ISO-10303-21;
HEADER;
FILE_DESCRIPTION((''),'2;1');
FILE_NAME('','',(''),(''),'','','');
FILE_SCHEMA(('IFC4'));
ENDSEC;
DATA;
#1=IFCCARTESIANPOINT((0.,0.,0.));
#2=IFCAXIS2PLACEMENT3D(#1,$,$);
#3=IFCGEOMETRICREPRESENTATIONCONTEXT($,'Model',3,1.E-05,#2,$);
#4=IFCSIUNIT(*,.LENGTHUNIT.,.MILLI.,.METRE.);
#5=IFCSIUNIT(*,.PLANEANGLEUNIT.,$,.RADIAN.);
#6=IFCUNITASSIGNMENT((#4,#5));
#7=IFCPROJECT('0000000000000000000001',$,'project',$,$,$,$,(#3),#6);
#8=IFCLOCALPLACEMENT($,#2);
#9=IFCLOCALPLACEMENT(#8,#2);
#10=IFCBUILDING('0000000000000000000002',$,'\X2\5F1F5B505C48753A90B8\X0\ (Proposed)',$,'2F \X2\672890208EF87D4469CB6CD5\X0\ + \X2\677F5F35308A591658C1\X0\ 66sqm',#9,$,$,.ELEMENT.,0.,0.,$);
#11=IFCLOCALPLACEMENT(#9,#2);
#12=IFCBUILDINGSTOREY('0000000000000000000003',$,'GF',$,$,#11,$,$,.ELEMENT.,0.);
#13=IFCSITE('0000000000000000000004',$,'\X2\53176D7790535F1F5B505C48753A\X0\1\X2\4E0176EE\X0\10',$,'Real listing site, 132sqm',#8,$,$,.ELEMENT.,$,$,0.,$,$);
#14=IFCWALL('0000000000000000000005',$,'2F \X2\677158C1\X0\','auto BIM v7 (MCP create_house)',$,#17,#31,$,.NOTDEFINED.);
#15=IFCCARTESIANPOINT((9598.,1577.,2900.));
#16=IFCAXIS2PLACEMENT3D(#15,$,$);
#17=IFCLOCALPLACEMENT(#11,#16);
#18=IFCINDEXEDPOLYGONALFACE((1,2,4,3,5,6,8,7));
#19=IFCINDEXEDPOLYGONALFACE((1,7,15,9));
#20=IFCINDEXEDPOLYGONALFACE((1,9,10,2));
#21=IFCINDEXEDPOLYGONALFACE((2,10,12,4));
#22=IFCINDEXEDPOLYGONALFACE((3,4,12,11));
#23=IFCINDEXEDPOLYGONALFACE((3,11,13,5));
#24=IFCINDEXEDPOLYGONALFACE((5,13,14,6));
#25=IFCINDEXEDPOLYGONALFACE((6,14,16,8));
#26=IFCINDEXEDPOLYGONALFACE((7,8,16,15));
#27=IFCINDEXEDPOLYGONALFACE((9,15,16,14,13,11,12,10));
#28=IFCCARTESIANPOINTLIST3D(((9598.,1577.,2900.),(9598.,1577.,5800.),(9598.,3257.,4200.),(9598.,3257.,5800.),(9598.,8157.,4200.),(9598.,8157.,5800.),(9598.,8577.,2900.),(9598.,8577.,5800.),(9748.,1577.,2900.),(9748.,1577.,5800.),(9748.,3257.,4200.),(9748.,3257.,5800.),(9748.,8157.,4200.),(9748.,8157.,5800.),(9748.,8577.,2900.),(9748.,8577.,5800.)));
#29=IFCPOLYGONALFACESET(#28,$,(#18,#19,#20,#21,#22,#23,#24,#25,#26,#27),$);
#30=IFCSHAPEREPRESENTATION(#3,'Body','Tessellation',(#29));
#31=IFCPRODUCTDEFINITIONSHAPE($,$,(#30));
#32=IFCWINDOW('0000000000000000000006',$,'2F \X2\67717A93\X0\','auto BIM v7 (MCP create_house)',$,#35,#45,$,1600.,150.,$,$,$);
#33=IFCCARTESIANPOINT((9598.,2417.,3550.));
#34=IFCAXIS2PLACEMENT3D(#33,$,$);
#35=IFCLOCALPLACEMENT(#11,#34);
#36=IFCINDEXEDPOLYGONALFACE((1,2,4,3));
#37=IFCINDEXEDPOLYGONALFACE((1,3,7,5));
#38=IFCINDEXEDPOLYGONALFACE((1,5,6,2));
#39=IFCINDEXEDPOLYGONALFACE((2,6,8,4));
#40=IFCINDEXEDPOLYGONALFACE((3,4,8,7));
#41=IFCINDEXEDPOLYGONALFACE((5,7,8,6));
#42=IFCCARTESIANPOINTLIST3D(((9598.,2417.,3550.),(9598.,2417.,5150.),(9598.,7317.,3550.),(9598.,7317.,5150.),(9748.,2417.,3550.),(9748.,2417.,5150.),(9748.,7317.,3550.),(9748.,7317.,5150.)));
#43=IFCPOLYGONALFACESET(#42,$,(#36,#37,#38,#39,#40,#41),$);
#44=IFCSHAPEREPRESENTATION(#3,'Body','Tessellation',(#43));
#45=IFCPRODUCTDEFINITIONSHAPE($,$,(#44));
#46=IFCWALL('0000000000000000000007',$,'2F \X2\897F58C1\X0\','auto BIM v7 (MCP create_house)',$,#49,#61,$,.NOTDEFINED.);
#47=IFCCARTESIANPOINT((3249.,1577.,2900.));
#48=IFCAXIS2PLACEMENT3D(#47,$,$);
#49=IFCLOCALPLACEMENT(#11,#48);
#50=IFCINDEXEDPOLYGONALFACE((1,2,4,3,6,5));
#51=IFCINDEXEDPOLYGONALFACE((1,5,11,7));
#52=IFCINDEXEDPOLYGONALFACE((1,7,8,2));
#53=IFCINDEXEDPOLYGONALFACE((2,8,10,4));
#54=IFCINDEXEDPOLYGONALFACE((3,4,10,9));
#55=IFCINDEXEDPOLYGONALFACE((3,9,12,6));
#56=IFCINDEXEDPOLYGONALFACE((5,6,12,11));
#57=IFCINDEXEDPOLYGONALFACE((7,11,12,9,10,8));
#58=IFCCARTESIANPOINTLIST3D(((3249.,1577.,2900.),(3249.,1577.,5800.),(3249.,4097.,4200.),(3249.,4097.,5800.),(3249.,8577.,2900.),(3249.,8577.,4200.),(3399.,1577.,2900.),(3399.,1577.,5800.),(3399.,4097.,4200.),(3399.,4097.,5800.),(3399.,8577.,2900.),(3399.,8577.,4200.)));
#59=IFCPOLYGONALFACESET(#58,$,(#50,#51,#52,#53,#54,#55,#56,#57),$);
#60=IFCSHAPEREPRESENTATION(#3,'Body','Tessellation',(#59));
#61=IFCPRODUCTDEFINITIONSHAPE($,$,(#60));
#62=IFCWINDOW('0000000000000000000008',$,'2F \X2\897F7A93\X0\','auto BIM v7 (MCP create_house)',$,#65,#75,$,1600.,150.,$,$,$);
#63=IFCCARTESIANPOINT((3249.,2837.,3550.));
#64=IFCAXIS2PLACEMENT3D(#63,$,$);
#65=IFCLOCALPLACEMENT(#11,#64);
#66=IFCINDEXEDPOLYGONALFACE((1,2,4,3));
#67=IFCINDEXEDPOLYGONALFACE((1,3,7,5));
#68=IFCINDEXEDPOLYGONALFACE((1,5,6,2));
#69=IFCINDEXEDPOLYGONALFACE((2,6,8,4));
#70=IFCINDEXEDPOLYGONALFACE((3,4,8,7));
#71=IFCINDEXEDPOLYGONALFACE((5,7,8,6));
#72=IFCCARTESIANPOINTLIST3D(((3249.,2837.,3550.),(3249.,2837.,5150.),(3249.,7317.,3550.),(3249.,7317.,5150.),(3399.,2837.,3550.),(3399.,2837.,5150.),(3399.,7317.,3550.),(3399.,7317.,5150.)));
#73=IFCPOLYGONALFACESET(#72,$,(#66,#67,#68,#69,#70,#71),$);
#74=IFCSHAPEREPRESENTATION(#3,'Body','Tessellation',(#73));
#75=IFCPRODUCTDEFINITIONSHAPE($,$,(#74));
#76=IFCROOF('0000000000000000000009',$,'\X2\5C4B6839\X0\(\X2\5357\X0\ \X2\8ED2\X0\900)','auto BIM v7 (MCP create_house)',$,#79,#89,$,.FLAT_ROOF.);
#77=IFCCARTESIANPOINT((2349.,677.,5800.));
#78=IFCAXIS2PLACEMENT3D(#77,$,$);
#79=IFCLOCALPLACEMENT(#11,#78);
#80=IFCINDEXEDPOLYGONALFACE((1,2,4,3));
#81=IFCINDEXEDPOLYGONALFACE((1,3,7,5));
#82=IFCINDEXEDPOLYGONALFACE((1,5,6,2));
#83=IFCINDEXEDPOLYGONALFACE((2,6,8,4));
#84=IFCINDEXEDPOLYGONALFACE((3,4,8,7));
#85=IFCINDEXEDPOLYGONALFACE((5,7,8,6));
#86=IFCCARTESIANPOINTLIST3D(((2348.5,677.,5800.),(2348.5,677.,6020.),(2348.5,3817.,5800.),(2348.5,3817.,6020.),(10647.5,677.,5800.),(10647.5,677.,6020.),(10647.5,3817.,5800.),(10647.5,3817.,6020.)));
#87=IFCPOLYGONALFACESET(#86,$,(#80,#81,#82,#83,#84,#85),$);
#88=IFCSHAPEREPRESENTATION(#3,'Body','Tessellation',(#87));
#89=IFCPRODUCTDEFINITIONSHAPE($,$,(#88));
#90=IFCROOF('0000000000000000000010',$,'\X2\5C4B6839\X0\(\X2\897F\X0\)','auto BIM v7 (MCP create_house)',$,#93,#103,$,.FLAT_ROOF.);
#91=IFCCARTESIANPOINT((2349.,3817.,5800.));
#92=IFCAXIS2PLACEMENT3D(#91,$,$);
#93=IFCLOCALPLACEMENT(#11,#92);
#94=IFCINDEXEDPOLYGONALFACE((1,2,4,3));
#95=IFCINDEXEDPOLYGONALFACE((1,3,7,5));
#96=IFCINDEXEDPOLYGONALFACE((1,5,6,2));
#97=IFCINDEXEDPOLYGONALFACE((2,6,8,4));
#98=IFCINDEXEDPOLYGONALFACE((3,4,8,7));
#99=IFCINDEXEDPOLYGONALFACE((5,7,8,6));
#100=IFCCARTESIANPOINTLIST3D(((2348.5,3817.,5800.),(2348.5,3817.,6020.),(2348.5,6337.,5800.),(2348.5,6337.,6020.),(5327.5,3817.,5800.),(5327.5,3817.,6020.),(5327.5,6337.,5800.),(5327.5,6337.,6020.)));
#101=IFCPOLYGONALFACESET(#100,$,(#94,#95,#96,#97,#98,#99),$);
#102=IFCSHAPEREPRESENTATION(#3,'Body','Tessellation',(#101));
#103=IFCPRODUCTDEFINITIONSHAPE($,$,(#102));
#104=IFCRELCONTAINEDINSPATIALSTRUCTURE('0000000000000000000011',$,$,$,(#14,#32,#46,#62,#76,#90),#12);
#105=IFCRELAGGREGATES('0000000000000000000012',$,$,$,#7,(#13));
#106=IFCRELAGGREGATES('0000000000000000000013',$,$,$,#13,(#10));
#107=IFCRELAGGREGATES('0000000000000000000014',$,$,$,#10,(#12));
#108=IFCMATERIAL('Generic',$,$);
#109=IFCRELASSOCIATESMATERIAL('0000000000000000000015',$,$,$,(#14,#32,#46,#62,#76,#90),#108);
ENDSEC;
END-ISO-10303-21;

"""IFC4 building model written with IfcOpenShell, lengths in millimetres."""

from ifc_helpers import new_model, si_unit, frame, frame_2d, origin, place, context, project, spatial, rectangle, extrude, material, element, fill, save


model = new_model("IFC4")

# Units and contexts
model_context = context("Model", 3, precision=1e-05, world=origin())
ifc_project = project(units=[si_unit("LENGTHUNIT", "METRE", prefix="MILLI"), si_unit("PLANEANGLEUNIT", "RADIAN")], contexts=[model_context])

# Site, building, storey
site_placement = place(None, origin())
site = spatial("IfcSite", under=ifc_project, at=site_placement, Name="北海道弟子屈町1丁目10", ObjectType="Real listing site, 132sqm", CompositionType="ELEMENT", RefElevation=0.0)
building_placement = place(site_placement, origin())
building = spatial("IfcBuilding", under=site, at=building_placement, Name="弟子屈町邸 (Proposed)", ObjectType="2F 木造軸組構法 + 板張り外壁 66sqm", CompositionType="ELEMENT", ElevationOfRefHeight=0.0, ElevationOfTerrain=0.0)
storey_placement = place(building_placement, origin())
storey = spatial("IfcBuildingStorey", under=building, at=storey_placement, Name="GF", CompositionType="ELEMENT", Elevation=0.0)

# Shared definitions
ifc_material = material(Name="Generic")

# Walls, openings, windows
wall_1_placement = place(storey_placement, frame((9598.0, 1577.0, 2900.0)))
wall_1 = element("IfcWall", 1, at=wall_1_placement, inside=storey, material=ifc_material, Name="2F 東壁", Description="auto BIM v7 (MCP create_house)", PredefinedType="NOTDEFINED", context=model_context, shape_type="SweptSolid", body=[
    extrude(rectangle(XDim=150.0, YDim=7000.0, at=frame_2d((75.0, 3500.0))), frame((9598.0, 1577.0, 2900.0)), (0.0, 0.0, 1.0), 2900.0),
])
opening_1_placement = place(storey_placement, frame((9598.0, 2417.0, 3550.0)))
opening_1 = element("IfcOpeningElement", 2, at=opening_1_placement, cuts=wall_1, PredefinedType="NOTDEFINED", context=model_context, shape_type="SweptSolid", body=[
    extrude(rectangle(XDim=150.0, YDim=4900.0, at=frame_2d((75.0, 2450.0))), frame((9598.0, 2417.0, 3550.0)), (0.0, 0.0, 1.0), 1600.0),
])
window_1_placement = place(storey_placement, frame((9598.0, 2417.0, 3550.0)))
window_1 = element("IfcWindow", 3, at=window_1_placement, inside=storey, material=ifc_material, Name="2F 東窓", Description="auto BIM v7 (MCP create_house)", OverallHeight=1600.0, OverallWidth=150.0, context=model_context, shape_type="SweptSolid", body=[
    extrude(rectangle(XDim=150.0, YDim=4900.0, at=frame_2d((75.0, 2450.0))), frame((9598.0, 2417.0, 3550.0)), (0.0, 0.0, 1.0), 1600.0),
])
fill(opening_1, window_1)
wall_2_placement = place(storey_placement, frame((3249.0, 1577.0, 2900.0)))
wall_2 = element("IfcWall", 4, at=wall_2_placement, inside=storey, material=ifc_material, Name="2F 西壁", Description="auto BIM v7 (MCP create_house)", PredefinedType="NOTDEFINED", context=model_context, shape_type="SweptSolid", body=[
    extrude(rectangle(XDim=150.0, YDim=7000.0, at=frame_2d((75.0, 3500.0))), frame((3249.0, 1577.0, 2900.0)), (0.0, 0.0, 1.0), 2900.0),
])
opening_2_placement = place(storey_placement, frame((3249.0, 2837.0, 3550.0)))
opening_2 = element("IfcOpeningElement", 5, at=opening_2_placement, cuts=wall_2, PredefinedType="NOTDEFINED", context=model_context, shape_type="SweptSolid", body=[
    extrude(rectangle(XDim=150.0, YDim=4480.0, at=frame_2d((75.0, 2240.0))), frame((3249.0, 2837.0, 3550.0)), (0.0, 0.0, 1.0), 1600.0),
])
window_2_placement = place(storey_placement, frame((3249.0, 2837.0, 3550.0)))
window_2 = element("IfcWindow", 6, at=window_2_placement, inside=storey, material=ifc_material, Name="2F 西窓", Description="auto BIM v7 (MCP create_house)", OverallHeight=1600.0, OverallWidth=150.0, context=model_context, shape_type="SweptSolid", body=[
    extrude(rectangle(XDim=150.0, YDim=4480.0, at=frame_2d((75.0, 2240.0))), frame((3249.0, 2837.0, 3550.0)), (0.0, 0.0, 1.0), 1600.0),
])
fill(opening_2, window_2)

# Roofs
roof_1_placement = place(storey_placement, frame((2349.0, 677.0, 5800.0)))
element("IfcRoof", 7, at=roof_1_placement, inside=storey, material=ifc_material, Name="屋根(南 軒900)", Description="auto BIM v7 (MCP create_house)", PredefinedType="FLAT_ROOF", context=model_context, shape_type="SweptSolid", body=[
    extrude(rectangle(XDim=8299.0, YDim=3140.0, at=frame_2d((4149.0, 1570.0))), frame((2349.0, 677.0, 5800.0)), (0.0, 0.0, 1.0), 220.0),
])
roof_2_placement = place(storey_placement, frame((2349.0, 3817.0, 5800.0)))
element("IfcRoof", 8, at=roof_2_placement, inside=storey, material=ifc_material, Name="屋根(西)", Description="auto BIM v7 (MCP create_house)", PredefinedType="FLAT_ROOF", context=model_context, shape_type="SweptSolid", body=[
    extrude(rectangle(XDim=2979.0, YDim=2520.0, at=frame_2d((1489.0, 1260.0))), frame((2349.0, 3817.0, 5800.0)), (0.0, 0.0, 1.0), 220.0),
])

save(model, "model.ifc")
